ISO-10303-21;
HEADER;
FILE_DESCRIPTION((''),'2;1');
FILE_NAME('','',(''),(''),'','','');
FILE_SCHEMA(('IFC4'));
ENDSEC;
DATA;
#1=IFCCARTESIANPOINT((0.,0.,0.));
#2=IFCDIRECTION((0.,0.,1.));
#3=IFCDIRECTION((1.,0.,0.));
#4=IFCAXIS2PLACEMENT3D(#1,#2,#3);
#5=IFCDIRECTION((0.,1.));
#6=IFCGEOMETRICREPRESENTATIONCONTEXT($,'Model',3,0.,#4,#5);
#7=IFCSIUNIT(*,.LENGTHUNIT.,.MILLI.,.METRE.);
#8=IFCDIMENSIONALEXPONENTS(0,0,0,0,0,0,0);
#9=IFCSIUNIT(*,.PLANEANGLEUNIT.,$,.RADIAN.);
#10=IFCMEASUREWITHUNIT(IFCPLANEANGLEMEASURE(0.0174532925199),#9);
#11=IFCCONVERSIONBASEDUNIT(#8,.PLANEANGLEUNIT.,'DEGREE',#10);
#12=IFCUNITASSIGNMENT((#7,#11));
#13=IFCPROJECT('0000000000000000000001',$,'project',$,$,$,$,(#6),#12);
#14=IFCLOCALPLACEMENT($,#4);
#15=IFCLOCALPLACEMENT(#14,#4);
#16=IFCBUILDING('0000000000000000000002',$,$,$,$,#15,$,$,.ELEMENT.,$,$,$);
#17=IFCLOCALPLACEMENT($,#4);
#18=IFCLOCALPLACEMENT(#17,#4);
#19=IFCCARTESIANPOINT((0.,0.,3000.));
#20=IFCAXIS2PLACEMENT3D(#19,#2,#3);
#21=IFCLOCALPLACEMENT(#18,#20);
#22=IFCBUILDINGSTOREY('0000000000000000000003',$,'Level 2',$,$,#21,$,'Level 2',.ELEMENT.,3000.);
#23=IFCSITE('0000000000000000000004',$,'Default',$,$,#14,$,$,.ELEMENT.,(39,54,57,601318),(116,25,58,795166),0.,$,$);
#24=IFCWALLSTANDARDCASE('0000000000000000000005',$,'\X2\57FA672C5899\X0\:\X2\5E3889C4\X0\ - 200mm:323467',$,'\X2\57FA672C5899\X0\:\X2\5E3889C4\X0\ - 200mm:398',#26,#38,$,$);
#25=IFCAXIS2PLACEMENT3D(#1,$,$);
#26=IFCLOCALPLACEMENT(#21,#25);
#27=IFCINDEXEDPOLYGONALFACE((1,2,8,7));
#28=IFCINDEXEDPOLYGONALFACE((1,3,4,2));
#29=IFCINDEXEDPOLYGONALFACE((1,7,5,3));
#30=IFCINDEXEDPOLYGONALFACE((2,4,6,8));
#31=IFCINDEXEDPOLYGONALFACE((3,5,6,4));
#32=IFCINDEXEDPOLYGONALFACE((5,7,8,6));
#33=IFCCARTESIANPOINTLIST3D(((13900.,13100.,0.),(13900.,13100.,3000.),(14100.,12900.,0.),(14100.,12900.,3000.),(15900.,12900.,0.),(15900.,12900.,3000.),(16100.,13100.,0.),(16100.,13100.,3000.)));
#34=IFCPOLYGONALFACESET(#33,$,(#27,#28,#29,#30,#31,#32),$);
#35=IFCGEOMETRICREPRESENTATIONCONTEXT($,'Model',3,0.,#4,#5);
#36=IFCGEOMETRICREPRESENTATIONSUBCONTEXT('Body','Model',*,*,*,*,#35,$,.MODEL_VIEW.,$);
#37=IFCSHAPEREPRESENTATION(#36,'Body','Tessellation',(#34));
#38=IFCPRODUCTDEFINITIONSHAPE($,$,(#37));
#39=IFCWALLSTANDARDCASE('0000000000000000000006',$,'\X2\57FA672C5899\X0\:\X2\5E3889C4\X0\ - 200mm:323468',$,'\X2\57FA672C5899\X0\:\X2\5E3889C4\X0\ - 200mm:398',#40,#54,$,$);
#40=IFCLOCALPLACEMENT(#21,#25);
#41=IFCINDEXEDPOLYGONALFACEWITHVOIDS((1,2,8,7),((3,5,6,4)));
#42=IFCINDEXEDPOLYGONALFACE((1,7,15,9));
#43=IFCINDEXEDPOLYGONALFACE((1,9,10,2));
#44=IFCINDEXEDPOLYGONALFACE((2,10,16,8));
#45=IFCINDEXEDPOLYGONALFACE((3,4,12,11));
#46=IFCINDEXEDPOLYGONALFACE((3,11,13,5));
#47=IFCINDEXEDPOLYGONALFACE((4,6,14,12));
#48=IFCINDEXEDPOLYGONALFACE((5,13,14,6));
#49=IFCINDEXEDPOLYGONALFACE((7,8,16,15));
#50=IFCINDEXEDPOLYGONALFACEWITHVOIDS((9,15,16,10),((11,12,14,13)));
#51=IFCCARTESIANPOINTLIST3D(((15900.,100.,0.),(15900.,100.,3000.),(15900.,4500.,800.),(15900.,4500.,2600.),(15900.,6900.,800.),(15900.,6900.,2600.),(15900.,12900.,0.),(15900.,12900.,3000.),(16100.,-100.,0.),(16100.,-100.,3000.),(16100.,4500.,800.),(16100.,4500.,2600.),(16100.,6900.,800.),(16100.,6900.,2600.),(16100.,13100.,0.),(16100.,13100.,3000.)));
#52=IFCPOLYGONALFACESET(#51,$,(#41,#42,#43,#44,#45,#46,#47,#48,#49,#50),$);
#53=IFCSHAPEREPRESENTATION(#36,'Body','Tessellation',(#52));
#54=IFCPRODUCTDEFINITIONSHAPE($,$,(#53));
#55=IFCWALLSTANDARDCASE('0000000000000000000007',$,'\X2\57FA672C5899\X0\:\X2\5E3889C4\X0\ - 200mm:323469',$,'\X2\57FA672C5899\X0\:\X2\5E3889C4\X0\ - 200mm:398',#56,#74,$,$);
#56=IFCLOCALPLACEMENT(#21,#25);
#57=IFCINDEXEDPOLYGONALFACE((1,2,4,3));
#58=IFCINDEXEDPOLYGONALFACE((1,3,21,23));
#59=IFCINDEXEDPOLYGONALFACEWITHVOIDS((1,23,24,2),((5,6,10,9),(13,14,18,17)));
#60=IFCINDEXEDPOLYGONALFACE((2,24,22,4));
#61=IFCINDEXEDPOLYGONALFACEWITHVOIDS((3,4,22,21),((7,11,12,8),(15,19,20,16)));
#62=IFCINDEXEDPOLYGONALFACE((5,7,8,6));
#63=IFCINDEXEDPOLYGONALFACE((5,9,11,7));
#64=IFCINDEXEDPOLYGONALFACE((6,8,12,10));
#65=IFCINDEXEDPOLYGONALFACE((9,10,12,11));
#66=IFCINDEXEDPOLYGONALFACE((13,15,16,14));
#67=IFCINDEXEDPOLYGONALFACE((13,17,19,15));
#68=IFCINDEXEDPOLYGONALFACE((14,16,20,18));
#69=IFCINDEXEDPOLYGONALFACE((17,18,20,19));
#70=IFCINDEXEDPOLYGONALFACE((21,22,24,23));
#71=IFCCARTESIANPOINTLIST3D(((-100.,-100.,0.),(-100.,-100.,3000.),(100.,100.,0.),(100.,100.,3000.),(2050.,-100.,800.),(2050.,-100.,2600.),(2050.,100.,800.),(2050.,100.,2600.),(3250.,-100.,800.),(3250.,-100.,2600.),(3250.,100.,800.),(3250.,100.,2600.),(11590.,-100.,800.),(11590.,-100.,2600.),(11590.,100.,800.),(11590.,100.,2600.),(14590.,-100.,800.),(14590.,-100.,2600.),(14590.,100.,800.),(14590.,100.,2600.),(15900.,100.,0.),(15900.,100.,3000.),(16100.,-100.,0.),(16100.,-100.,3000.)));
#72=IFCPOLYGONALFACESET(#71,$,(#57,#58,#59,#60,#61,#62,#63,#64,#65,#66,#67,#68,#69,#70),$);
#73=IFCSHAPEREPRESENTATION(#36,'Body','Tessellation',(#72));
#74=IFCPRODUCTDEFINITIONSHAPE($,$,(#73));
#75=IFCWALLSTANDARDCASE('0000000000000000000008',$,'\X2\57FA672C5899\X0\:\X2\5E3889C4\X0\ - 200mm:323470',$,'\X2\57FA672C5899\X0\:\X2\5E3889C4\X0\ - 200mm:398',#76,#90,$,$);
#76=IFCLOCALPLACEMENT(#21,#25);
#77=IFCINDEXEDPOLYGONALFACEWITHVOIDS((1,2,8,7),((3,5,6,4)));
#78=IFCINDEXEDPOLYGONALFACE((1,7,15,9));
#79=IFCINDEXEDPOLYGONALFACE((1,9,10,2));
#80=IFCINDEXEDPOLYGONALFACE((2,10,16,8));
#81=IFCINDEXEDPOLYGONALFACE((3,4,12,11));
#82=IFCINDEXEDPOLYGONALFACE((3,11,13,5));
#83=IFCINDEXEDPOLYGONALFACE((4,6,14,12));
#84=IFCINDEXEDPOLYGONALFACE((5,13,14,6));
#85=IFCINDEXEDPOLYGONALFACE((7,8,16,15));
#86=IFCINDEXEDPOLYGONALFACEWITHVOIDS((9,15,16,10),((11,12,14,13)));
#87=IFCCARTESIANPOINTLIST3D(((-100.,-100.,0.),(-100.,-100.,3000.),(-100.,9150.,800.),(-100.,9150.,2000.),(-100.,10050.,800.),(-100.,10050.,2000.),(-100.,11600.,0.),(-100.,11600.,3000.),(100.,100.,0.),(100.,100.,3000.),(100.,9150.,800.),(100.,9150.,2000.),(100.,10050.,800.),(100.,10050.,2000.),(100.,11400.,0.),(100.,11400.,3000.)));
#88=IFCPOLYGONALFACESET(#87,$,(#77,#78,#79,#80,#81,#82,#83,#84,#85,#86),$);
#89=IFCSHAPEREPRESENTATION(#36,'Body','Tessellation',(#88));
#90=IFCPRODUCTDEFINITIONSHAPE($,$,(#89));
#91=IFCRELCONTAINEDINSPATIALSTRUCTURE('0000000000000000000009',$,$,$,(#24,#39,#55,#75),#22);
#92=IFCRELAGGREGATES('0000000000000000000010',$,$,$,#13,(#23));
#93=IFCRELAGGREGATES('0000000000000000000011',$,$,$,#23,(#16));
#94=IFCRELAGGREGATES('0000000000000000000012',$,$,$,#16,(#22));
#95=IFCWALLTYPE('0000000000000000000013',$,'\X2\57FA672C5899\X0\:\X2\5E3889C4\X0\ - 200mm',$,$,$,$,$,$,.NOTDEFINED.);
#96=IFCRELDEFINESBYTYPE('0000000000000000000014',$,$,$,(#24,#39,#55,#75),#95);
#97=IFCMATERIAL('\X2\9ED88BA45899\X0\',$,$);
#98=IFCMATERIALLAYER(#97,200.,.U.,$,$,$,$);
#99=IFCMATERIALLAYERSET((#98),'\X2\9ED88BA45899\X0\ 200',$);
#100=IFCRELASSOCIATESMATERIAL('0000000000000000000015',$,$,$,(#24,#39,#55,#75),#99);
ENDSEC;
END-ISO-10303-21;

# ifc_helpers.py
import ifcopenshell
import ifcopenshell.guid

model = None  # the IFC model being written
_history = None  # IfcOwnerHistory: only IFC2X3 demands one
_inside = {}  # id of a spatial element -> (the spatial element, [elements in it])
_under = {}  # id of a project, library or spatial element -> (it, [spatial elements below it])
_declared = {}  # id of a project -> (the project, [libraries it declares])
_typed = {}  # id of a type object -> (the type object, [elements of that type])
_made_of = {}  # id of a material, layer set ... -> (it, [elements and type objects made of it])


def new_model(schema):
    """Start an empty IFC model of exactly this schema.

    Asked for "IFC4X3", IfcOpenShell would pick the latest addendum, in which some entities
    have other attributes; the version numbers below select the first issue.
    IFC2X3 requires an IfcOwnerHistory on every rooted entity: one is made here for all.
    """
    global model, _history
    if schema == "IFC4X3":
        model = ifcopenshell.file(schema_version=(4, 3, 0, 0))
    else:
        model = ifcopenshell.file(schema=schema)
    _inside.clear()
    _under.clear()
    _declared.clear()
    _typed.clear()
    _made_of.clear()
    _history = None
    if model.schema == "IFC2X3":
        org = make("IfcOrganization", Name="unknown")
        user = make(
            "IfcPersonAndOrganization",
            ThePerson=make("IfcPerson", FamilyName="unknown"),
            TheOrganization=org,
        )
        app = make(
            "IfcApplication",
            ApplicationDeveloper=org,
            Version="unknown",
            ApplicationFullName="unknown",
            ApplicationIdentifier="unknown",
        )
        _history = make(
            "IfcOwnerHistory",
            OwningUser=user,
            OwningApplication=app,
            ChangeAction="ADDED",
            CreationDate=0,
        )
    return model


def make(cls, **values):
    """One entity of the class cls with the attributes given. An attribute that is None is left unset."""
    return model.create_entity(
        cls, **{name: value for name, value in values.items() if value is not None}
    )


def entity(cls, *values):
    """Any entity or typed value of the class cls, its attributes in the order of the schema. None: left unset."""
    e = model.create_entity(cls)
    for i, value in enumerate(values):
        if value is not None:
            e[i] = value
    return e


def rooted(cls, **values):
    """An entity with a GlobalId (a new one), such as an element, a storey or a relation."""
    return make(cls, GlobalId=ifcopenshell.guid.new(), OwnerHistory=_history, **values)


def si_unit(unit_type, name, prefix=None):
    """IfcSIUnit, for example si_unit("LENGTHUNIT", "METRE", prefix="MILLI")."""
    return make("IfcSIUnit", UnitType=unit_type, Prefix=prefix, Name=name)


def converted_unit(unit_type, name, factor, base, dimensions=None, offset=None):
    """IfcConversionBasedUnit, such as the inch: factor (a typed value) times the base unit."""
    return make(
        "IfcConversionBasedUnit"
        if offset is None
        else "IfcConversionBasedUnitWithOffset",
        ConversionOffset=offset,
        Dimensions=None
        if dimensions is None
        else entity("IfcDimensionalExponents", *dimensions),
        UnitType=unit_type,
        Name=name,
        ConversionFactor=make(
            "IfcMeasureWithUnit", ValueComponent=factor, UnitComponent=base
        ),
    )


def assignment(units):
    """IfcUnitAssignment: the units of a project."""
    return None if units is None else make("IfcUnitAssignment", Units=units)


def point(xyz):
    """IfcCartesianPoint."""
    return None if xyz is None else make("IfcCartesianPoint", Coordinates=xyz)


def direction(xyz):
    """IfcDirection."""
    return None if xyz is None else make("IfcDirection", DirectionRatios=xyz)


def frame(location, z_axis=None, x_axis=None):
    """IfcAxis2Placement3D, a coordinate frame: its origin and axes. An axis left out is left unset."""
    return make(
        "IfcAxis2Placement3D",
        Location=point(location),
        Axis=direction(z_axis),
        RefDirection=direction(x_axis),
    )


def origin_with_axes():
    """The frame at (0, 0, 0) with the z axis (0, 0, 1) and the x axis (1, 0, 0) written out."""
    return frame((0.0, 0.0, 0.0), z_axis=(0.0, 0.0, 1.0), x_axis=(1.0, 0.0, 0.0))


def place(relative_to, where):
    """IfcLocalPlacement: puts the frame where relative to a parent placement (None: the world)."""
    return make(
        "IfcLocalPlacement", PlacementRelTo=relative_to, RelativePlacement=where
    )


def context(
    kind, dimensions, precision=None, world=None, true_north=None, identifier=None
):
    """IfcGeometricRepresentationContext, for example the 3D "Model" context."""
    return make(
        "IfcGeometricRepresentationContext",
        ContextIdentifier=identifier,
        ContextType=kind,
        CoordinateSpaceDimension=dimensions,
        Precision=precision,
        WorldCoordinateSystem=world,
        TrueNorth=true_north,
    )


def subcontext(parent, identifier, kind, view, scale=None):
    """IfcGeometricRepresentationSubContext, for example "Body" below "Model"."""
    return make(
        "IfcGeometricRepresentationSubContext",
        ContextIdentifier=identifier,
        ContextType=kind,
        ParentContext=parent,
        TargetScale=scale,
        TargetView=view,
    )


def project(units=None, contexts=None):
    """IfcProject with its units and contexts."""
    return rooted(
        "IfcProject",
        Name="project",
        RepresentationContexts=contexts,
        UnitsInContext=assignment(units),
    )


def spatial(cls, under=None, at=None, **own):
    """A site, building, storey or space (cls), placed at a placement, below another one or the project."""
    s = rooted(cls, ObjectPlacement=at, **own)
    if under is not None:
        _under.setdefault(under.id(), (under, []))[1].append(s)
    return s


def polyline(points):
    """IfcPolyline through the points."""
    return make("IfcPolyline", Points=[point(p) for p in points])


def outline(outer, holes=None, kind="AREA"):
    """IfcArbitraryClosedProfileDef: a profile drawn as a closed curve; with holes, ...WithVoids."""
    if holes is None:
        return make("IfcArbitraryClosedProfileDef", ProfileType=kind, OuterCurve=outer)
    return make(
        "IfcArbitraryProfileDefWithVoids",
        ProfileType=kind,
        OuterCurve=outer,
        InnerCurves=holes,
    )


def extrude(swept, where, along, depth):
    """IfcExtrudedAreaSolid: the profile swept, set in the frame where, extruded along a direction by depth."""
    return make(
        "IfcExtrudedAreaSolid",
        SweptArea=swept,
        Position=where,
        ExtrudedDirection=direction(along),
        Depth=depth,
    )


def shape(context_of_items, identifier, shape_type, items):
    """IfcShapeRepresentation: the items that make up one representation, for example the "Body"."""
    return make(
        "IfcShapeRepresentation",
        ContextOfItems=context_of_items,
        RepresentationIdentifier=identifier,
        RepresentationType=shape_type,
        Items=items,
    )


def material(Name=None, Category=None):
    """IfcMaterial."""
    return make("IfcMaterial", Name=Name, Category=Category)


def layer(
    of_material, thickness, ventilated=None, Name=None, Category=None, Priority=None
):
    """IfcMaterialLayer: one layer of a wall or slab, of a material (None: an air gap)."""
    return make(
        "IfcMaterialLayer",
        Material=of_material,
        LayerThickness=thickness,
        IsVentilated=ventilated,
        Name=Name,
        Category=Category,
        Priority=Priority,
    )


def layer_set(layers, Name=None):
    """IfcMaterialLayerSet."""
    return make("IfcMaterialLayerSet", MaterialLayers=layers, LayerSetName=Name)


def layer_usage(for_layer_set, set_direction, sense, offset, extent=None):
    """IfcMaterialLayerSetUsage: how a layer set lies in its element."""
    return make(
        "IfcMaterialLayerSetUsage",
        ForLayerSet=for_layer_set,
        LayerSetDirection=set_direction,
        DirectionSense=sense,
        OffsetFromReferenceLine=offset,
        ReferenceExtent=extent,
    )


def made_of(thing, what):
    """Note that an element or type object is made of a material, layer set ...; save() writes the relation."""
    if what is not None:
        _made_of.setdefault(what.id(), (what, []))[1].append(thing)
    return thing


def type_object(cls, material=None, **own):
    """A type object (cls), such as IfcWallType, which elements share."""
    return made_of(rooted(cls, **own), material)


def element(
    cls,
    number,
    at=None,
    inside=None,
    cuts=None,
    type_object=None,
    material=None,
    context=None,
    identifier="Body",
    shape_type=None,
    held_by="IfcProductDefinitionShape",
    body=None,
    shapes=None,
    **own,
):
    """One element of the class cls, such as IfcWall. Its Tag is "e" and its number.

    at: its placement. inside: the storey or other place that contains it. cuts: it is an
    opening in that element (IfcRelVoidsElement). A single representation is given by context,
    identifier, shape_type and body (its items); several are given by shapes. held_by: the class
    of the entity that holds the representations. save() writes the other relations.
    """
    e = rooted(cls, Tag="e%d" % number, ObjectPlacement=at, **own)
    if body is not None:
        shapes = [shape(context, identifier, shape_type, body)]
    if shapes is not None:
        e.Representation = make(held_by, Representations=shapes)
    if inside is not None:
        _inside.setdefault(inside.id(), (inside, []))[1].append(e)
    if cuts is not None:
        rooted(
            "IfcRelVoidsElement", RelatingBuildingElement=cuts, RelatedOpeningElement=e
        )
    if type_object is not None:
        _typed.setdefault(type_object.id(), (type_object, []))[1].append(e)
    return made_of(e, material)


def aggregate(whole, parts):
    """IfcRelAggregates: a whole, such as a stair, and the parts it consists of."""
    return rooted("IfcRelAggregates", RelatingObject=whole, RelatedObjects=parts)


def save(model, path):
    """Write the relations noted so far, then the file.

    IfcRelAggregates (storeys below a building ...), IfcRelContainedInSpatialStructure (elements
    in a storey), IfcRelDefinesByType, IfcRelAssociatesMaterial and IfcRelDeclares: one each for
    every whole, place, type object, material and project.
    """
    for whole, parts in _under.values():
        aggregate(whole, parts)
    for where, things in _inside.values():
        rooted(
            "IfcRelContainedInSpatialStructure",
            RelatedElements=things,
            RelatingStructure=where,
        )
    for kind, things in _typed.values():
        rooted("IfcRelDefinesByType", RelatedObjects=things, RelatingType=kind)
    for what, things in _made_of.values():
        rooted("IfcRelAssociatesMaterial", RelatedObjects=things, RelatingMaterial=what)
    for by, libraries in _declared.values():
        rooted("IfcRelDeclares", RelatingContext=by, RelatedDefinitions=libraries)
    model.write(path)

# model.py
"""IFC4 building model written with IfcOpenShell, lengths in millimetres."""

from ifc_helpers import new_model, entity, si_unit, converted_unit, direction, frame, origin_with_axes, place, context, subcontext, project, spatial, polyline, outline, extrude, material, layer, layer_set, layer_usage, type_object, element, save


model = new_model("IFC4")

# Units and contexts
model_context_1 = context("Model", 3, precision=0.0, world=origin_with_axes(), true_north=direction((0.0, 1.0)))
model_context_2 = context("Model", 3, precision=0.0, world=origin_with_axes(), true_north=direction((0.0, 1.0)))
body_context = subcontext(model_context_2, "Body", "Model", "MODEL_VIEW")
ifc_project = project(units=[si_unit("LENGTHUNIT", "METRE", prefix="MILLI"), converted_unit("PLANEANGLEUNIT", "DEGREE", entity("IfcPlaneAngleMeasure", 0.0174532925199), si_unit("PLANEANGLEUNIT", "RADIAN"), dimensions=[0, 0, 0, 0, 0, 0, 0])], contexts=[model_context_1])

# Site, building, storey
site_placement = place(None, origin_with_axes())
site = spatial("IfcSite", under=ifc_project, at=site_placement, Name="Default", CompositionType="ELEMENT", RefLatitude=(39, 54, 57, 601318), RefLongitude=(116, 25, 58, 795166), RefElevation=0.0)
building_placement = place(site_placement, origin_with_axes())
building = spatial("IfcBuilding", under=site, at=building_placement, CompositionType="ELEMENT")
placement_1 = place(None, origin_with_axes())
placement_2 = place(placement_1, origin_with_axes())
storey_placement = place(placement_2, frame((0.0, 0.0, 3000.0), z_axis=(0.0, 0.0, 1.0), x_axis=(1.0, 0.0, 0.0)))
storey = spatial("IfcBuildingStorey", under=building, at=storey_placement, Name="Level 2", LongName="Level 2", CompositionType="ELEMENT", Elevation=3000.0)

# Shared definitions
ifc_material_1 = material(Name="默认墙")
ifc_layer_1 = layer(ifc_material_1, 200.0, ventilated="UNKNOWN")
ifc_layer_set_1 = layer_set([ifc_layer_1], Name="默认墙 200")
wall_type = type_object("IfcWallType", Name="基本墙:常规 - 200mm", PredefinedType="NOTDEFINED")

# Wall
ifc_layer_usage_1 = layer_usage(ifc_layer_set_1, "AXIS2", "POSITIVE", -100.0)
wall_1_placement = place(storey_placement, frame((14000.0, 13000.0, 0.0), z_axis=(0.0, 0.0, 1.0), x_axis=(1.0, 0.0, 0.0)))
element("IfcWallStandardCase", 1, at=wall_1_placement, inside=storey, type_object=wall_type, material=ifc_layer_usage_1, Name="基本墙:常规 - 200mm:323467", ObjectType="基本墙:常规 - 200mm:398", context=body_context, shape_type="SweptSolid", body=[
    extrude(outline(polyline([(100.0, -100.0), (1900.0, -100.0), (2100.0, 100.0), (-100.0, 100.0), (100.0, -100.0)])), origin_with_axes(), (0.0, 0.0, 1.0), 3000.0),
])

# Wall, opening
ifc_layer_usage_2 = layer_usage(ifc_layer_set_1, "AXIS2", "POSITIVE", -100.0)
wall_2_placement = place(storey_placement, frame((16000.0, 13000.0, 0.0), z_axis=(0.0, 0.0, 1.0), x_axis=(0.0, -1.0, 0.0)))
wall_2 = element("IfcWallStandardCase", 2, at=wall_2_placement, inside=storey, type_object=wall_type, material=ifc_layer_usage_2, Name="基本墙:常规 - 200mm:323468", ObjectType="基本墙:常规 - 200mm:398", context=body_context, shape_type="SweptSolid", body=[
    extrude(outline(polyline([(100.0, -100.0), (12900.0, -100.0), (13100.0, 100.0), (-100.0, 100.0), (100.0, -100.0)])), origin_with_axes(), (0.0, 0.0, 1.0), 3000.0),
])
opening_1_placement = place(wall_2_placement, frame((7300.0, 0.0, 800.0), z_axis=(0.0, 0.0, 1.0), x_axis=(1.0, 0.0, 0.0)))
element("IfcOpeningElement", 3, at=opening_1_placement, cuts=wall_2, context=body_context, shape_type="SweptSolid", body=[
    extrude(outline(polyline([(-1200.0, 0.0), (-1200.0, -1800.0), (1200.0, -1800.0), (1200.0, 0.0), (-1200.0, 0.0)])), frame((0.0, -100.0, 0.0), z_axis=(0.0, 1.0, 0.0), x_axis=(1.0, 0.0, 0.0)), (0.0, 0.0, 1.0), 200.0),
])

# Wall, openings
ifc_layer_usage_3 = layer_usage(ifc_layer_set_1, "AXIS2", "POSITIVE", -100.0)
wall_3_placement = place(storey_placement, frame((16000.0, 0.0, 0.0), z_axis=(0.0, 0.0, 1.0), x_axis=(-1.0, 0.0, 0.0)))
wall_3 = element("IfcWallStandardCase", 4, at=wall_3_placement, inside=storey, type_object=wall_type, material=ifc_layer_usage_3, Name="基本墙:常规 - 200mm:323469", ObjectType="基本墙:常规 - 200mm:398", context=body_context, shape_type="SweptSolid", body=[
    extrude(outline(polyline([(100.0, -100.0), (15900.0, -100.0), (16100.0, 100.0), (-100.0, 100.0), (100.0, -100.0)])), origin_with_axes(), (0.0, 0.0, 1.0), 3000.0),
])
opening_2_placement = place(wall_3_placement, frame((13350.0, 0.0, 800.0), z_axis=(0.0, 0.0, 1.0), x_axis=(1.0, 0.0, 0.0)))
element("IfcOpeningElement", 5, at=opening_2_placement, cuts=wall_3, context=body_context, shape_type="SweptSolid", body=[
    extrude(outline(polyline([(-600.0, 0.0), (-600.0, -1800.0), (600.0, -1800.0), (600.0, 0.0), (-600.0, 0.0)])), frame((0.0, -100.0, 0.0), z_axis=(0.0, 1.0, 0.0), x_axis=(1.0, 0.0, 0.0)), (0.0, 0.0, 1.0), 200.0),
])
opening_3_placement = place(wall_3_placement, frame((2910.0, 0.0, 800.0), z_axis=(0.0, 0.0, 1.0), x_axis=(1.0, 0.0, 0.0)))
element("IfcOpeningElement", 6, at=opening_3_placement, cuts=wall_3, context=body_context, shape_type="SweptSolid", body=[
    extrude(outline(polyline([(-1500.0, 0.0), (-1500.0, -1800.0), (1500.0, -1800.0), (1500.0, 0.0), (-1500.0, 0.0)])), frame((0.0, -100.0, 0.0), z_axis=(0.0, 1.0, 0.0), x_axis=(1.0, 0.0, 0.0)), (0.0, 0.0, 1.0), 200.0),
])

# Wall, opening
ifc_layer_usage_4 = layer_usage(ifc_layer_set_1, "AXIS2", "POSITIVE", -100.0)
wall_4_placement = place(storey_placement, frame((0.0, 0.0, 0.0), z_axis=(0.0, 0.0, 1.0), x_axis=(0.0, 1.0, 0.0)))
wall_4 = element("IfcWallStandardCase", 7, at=wall_4_placement, inside=storey, type_object=wall_type, material=ifc_layer_usage_4, Name="基本墙:常规 - 200mm:323470", ObjectType="基本墙:常规 - 200mm:398", context=body_context, shape_type="SweptSolid", body=[
    extrude(outline(polyline([(100.0, -100.0), (11400.0, -100.0), (11600.0, 100.0), (-100.0, 100.0), (100.0, -100.0)])), origin_with_axes(), (0.0, 0.0, 1.0), 3000.0),
])
opening_4_placement = place(wall_4_placement, frame((9600.0, 0.0, 800.0), z_axis=(0.0, 0.0, 1.0), x_axis=(1.0, 0.0, 0.0)))
element("IfcOpeningElement", 8, at=opening_4_placement, cuts=wall_4, context=body_context, shape_type="SweptSolid", body=[
    extrude(outline(polyline([(450.0, -1200.0), (450.0, 0.0), (-450.0, 0.0), (-450.0, -1200.0), (450.0, -1200.0)])), frame((0.0, 100.0, 0.0), z_axis=(0.0, -1.0, 0.0), x_axis=(-1.0, 0.0, 0.0)), (0.0, 0.0, 1.0), 200.0),
])

save(model, "model.ifc")
